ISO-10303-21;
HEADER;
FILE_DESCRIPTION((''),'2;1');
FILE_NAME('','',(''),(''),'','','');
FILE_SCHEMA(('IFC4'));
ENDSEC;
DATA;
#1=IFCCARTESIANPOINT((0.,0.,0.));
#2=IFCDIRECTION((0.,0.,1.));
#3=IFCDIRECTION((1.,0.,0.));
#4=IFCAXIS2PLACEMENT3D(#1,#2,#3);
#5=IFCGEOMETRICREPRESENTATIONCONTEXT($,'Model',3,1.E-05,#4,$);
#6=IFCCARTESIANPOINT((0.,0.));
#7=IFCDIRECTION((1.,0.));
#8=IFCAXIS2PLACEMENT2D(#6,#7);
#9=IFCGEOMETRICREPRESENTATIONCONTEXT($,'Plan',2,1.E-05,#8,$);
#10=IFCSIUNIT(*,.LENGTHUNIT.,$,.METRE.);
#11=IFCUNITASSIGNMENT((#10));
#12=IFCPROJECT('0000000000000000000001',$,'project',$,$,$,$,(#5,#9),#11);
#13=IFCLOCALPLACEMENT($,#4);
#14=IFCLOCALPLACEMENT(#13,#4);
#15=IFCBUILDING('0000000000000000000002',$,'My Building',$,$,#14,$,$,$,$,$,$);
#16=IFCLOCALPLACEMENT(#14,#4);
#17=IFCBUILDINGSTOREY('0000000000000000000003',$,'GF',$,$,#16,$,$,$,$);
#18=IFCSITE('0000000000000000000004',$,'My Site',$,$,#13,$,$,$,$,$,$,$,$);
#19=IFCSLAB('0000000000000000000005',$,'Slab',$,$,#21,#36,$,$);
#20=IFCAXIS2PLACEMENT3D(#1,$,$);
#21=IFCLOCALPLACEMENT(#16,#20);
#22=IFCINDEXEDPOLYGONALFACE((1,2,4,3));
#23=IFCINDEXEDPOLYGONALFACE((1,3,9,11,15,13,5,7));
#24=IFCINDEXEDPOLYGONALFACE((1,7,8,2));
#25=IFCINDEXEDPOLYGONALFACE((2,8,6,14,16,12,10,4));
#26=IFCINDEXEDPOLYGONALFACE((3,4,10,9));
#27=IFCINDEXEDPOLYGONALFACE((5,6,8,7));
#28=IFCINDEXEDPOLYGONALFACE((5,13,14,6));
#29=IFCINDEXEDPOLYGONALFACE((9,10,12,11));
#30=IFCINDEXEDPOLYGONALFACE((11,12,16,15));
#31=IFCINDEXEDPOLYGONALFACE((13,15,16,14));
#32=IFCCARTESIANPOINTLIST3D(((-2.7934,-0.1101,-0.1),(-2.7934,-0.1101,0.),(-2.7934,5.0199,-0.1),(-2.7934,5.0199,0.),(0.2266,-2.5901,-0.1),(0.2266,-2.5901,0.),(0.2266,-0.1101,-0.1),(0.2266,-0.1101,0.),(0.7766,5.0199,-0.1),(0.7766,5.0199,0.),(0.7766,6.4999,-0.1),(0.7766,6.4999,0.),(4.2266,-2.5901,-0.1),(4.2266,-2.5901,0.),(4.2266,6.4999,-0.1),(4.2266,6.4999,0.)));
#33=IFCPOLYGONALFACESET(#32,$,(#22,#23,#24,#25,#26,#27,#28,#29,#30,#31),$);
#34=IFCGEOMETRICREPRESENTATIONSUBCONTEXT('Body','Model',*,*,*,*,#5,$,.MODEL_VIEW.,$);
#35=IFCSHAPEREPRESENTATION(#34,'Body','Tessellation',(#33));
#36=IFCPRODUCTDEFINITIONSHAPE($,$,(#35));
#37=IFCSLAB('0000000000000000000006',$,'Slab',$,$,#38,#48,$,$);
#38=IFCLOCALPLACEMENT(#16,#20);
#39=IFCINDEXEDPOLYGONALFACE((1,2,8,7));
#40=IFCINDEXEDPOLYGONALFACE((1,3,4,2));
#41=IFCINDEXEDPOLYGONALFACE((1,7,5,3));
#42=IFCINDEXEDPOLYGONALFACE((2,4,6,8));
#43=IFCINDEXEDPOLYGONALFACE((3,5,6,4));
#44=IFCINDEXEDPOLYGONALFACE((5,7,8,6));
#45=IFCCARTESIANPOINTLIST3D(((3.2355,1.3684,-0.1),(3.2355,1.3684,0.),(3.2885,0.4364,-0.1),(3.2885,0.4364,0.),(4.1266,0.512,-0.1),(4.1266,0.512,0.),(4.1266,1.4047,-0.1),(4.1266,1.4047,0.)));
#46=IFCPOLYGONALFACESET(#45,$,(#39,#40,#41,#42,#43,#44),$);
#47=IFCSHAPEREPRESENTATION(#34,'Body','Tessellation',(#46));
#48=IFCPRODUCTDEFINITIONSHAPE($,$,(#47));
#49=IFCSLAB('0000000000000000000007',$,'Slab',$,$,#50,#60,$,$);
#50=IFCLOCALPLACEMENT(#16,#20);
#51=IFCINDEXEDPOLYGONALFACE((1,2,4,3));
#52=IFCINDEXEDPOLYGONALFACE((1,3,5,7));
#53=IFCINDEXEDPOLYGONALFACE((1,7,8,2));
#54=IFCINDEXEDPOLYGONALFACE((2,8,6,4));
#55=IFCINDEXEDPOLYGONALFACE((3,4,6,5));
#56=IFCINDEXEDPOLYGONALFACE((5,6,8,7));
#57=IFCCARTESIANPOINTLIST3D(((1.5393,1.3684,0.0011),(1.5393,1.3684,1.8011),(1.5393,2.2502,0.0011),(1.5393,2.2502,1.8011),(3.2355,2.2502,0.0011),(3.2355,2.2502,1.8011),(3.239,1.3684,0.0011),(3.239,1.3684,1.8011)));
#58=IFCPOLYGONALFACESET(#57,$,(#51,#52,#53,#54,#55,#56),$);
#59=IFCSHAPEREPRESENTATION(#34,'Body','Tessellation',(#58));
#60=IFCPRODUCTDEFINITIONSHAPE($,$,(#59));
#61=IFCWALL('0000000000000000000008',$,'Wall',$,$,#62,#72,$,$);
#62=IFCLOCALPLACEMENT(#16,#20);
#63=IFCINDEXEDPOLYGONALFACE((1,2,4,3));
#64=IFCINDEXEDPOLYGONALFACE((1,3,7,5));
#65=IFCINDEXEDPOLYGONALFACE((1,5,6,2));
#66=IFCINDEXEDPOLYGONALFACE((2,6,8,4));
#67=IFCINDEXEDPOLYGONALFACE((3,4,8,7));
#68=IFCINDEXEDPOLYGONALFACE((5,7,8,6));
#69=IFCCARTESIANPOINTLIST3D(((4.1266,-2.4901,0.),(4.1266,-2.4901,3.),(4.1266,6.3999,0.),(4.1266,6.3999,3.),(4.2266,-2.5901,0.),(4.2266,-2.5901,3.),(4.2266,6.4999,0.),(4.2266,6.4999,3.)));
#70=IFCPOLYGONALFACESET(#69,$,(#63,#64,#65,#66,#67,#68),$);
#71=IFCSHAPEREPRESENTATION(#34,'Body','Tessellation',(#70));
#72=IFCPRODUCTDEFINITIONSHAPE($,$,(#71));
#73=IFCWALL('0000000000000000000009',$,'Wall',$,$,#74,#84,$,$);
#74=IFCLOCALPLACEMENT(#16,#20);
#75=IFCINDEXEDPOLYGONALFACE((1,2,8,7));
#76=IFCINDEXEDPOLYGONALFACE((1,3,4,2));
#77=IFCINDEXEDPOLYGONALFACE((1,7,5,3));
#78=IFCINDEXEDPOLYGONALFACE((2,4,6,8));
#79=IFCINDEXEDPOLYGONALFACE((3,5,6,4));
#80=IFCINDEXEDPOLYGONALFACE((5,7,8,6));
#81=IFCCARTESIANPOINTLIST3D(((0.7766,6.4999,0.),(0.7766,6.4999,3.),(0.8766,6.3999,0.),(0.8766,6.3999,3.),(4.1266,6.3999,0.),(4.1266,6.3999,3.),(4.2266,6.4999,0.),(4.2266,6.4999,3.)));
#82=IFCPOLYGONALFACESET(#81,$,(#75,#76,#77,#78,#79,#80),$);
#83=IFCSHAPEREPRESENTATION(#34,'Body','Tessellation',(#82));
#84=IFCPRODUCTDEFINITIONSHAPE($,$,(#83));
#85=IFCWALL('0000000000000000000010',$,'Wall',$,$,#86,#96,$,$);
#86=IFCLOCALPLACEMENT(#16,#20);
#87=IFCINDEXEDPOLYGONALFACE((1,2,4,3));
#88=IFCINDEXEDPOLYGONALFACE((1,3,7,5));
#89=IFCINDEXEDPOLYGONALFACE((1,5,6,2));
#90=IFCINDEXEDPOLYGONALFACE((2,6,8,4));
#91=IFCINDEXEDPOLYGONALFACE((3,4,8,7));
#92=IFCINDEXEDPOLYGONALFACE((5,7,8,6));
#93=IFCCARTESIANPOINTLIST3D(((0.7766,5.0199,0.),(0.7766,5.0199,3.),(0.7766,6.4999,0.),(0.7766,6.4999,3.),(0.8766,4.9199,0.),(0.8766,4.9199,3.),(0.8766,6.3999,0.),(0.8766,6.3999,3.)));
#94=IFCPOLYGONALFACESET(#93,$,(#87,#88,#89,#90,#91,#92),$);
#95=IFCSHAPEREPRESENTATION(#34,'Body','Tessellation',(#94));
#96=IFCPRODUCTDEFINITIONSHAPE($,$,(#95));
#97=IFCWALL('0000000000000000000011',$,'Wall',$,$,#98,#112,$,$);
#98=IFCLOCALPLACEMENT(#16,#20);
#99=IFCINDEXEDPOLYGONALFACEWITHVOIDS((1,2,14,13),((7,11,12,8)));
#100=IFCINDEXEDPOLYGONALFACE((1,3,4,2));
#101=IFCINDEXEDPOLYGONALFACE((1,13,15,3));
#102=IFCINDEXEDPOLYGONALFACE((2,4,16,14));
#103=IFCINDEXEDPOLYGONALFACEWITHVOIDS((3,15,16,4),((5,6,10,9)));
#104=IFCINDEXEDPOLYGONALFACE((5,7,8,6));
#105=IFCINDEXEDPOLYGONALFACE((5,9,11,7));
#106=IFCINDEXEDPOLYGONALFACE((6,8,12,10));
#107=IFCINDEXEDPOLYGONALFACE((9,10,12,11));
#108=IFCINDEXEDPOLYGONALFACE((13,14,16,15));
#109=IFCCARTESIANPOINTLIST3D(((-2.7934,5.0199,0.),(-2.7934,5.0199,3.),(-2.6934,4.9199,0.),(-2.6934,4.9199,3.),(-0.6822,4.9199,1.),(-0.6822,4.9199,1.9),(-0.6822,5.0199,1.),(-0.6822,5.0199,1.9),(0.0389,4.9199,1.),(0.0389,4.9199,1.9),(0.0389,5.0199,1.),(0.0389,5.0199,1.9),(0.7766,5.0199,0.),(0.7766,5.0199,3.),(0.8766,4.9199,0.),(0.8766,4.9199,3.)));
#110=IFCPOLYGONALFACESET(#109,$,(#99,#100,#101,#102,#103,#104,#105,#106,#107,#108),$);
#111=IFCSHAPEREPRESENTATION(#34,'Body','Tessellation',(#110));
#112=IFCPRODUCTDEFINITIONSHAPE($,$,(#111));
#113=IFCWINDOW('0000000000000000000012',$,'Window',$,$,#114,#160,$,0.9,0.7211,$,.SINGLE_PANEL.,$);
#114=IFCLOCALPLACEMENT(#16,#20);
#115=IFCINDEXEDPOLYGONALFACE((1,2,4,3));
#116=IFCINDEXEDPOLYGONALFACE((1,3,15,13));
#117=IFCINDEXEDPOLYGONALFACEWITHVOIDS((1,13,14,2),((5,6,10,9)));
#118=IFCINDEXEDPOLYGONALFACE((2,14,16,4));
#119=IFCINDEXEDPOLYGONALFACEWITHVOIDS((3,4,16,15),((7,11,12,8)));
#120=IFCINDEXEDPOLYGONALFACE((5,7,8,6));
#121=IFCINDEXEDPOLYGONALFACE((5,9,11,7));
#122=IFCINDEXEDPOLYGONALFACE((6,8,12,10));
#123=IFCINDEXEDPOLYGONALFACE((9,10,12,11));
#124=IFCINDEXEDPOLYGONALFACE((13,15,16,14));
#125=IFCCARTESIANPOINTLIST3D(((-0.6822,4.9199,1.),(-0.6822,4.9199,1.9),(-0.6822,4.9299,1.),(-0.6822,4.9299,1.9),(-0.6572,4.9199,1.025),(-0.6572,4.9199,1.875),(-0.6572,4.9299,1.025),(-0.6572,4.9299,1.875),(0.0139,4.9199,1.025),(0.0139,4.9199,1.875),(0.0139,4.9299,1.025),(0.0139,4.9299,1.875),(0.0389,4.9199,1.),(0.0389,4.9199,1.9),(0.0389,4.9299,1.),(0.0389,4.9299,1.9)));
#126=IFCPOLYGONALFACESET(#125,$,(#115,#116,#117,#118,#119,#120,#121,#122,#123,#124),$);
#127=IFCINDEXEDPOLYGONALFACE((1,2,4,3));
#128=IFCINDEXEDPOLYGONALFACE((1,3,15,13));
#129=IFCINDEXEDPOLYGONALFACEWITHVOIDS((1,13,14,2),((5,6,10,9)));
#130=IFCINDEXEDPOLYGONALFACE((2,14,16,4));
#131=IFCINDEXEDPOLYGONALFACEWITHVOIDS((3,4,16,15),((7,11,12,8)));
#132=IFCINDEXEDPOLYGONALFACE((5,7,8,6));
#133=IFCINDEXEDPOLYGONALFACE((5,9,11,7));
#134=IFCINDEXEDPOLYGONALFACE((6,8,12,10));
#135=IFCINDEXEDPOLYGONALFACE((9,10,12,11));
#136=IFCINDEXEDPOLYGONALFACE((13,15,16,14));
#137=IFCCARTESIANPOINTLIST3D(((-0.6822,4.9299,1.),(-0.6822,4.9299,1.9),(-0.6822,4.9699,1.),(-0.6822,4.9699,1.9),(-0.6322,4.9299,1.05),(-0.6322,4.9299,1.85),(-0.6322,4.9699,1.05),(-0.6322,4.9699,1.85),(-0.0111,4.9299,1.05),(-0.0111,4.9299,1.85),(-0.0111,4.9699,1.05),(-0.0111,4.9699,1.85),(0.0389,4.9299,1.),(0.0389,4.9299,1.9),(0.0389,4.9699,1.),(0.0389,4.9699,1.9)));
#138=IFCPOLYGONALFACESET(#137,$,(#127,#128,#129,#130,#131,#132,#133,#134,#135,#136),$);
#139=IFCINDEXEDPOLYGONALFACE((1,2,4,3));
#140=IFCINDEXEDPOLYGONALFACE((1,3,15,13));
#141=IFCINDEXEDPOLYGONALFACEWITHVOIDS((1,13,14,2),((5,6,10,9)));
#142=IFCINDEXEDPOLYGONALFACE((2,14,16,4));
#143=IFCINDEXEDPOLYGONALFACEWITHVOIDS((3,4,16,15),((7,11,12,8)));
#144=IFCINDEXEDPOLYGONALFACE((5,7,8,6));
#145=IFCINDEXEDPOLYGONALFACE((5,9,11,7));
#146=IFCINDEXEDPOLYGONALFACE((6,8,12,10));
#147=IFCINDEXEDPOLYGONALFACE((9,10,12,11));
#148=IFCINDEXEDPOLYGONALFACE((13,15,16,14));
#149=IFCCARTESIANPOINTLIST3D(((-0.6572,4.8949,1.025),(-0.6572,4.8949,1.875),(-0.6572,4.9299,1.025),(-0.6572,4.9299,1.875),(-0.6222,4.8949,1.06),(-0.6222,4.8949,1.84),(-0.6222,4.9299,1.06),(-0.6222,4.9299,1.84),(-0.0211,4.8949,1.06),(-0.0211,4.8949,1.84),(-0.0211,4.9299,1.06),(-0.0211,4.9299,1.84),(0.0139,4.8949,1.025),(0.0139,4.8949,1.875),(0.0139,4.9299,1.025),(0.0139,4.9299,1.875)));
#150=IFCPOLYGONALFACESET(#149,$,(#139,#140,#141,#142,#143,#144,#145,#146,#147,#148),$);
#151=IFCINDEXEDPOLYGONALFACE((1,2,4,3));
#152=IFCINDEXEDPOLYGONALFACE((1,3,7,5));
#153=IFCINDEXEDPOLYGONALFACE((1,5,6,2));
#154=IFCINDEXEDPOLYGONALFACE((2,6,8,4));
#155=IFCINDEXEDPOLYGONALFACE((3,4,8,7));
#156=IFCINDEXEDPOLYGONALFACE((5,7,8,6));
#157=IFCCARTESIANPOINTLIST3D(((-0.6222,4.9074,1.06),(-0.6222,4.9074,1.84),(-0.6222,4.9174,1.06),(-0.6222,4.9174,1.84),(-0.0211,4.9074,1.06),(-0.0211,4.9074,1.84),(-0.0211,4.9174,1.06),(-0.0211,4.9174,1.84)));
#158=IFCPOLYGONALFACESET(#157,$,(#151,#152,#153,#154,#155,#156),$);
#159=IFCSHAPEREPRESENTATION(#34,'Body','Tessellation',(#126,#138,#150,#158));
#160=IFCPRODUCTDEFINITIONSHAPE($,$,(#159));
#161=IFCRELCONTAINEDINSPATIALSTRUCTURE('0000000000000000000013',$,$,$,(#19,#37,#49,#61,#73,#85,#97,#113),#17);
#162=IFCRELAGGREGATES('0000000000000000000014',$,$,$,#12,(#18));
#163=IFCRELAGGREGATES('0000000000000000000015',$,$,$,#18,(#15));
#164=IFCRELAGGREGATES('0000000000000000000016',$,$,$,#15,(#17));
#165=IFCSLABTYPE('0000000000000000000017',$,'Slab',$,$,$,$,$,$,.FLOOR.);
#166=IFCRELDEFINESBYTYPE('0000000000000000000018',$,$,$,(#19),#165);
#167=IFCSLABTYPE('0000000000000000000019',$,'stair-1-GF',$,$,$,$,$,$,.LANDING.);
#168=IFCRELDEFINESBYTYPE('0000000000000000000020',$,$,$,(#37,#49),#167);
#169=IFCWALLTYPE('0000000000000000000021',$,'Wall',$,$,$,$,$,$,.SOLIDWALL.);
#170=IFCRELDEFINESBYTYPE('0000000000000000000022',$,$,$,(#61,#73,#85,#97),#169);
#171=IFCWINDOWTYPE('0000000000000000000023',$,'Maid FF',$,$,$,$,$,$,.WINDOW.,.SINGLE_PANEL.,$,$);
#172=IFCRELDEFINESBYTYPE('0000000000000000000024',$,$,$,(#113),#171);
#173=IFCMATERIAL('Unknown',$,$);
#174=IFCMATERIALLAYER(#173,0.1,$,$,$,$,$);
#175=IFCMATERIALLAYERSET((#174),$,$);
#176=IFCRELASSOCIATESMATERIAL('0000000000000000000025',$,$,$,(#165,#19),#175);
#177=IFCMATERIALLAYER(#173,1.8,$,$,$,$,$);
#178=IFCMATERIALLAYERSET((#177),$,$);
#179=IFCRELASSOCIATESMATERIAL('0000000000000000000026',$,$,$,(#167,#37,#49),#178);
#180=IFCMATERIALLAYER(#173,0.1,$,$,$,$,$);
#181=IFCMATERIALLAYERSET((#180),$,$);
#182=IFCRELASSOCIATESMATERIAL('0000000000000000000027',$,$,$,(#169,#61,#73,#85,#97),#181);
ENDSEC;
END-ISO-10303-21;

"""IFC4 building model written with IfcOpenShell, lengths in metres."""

from ifc_helpers import new_model, entity, si_unit, frame, origin_with_axes, origin_2d_with_axis, place, context, subcontext, project, spatial, line, indexed_curve, outline, extrude, shape, source, transform, mapped, material, layer, layer_set, layer_usage, type_object, type_shapes, element, fill, save


model = new_model("IFC4")

# Units and contexts
model_context = context("Model", 3, precision=1e-05, world=origin_with_axes())
plan_context = context("Plan", 2, precision=1e-05, world=origin_2d_with_axis())
body_context_1 = subcontext(model_context, "Body", "Model", "MODEL_VIEW")
body_context_2 = subcontext(plan_context, "Body", "Plan", "PLAN_VIEW")
ifc_project = project(units=[si_unit("LENGTHUNIT", "METRE")], contexts=[model_context, plan_context])

# Site, building, storey
site_placement = place(None, origin_with_axes())
site = spatial("IfcSite", under=ifc_project, at=site_placement, Name="My Site")
building_placement = place(site_placement, origin_with_axes())
building = spatial("IfcBuilding", under=site, at=building_placement, Name="My Building")
storey_placement = place(building_placement, origin_with_axes())
storey = spatial("IfcBuildingStorey", under=building, at=storey_placement, Name="GF")

# Slabs
ifc_material_1 = material(Name="Unknown")
ifc_layer_1 = layer(ifc_material_1, 0.1)
ifc_layer_set_1 = layer_set([ifc_layer_1])
ifc_layer_usage_1 = layer_usage(ifc_layer_set_1, "AXIS3", "POSITIVE", -0.1)
slab_type_1 = type_object("IfcSlabType", Name="Slab", PredefinedType="FLOOR", material=ifc_layer_set_1)
slab_1_placement = place(storey_placement, frame((4.2266, -2.5901, 0.0), z_axis=(0.0, 0.0, 1.0), x_axis=(1.0, 0.0, 0.0)))
element("IfcSlab", 1, at=slab_1_placement, inside=storey, type_object=slab_type_1, material=ifc_layer_usage_1, Name="Slab", context=body_context_1, shape_type="SweptSolid", body=[
    extrude(outline(indexed_curve([(0.0, 0.0), (0.0, 9.09), (-3.45, 9.09), (-3.45, 7.61), (-7.02, 7.61), (-7.02, 2.48), (-4.0, 2.48), (-4.0, 0.0), (0.0, 0.0)])), frame((0.0, 0.0, -0.1), z_axis=(0.0, 0.0, 1.0), x_axis=(1.0, 0.0, 0.0)), (0.0, 0.0, 1.0), 0.1),
])
ifc_layer_2 = layer(ifc_material_1, 1.8)
ifc_layer_set_2 = layer_set([ifc_layer_2])
ifc_layer_usage_2 = layer_usage(ifc_layer_set_2, "AXIS3", "POSITIVE", -0.1)
slab_type_2 = type_object("IfcSlabType", Name="stair-1-GF", PredefinedType="LANDING", material=ifc_layer_set_2)
slab_2_placement = place(storey_placement, frame((4.1266, 0.512, 0.0), z_axis=(0.0, 0.0, 1.0), x_axis=(1.0, 0.0, 0.0)))
element("IfcSlab", 2, at=slab_2_placement, inside=storey, type_object=slab_type_2, material=ifc_layer_usage_2, Name="Slab", context=body_context_1, shape_type="SweptSolid", body=[
    extrude(outline(indexed_curve([(0.0, 0.0), (0.0, 0.8927), (-0.8911, 0.8564), (-0.8381, -0.0756), (0.0, 0.0)])), frame((0.0, 0.0, -0.1), z_axis=(0.0, 0.0, 1.0), x_axis=(1.0, 0.0, 0.0)), (0.0, 0.0, 1.0), 0.1),
])
ifc_layer_usage_3 = layer_usage(ifc_layer_set_2, "AXIS3", "POSITIVE", -1.8)
slab_3_placement = place(storey_placement, frame((3.239, 1.3684, 1.8011), z_axis=(0.0, 0.0, 1.0), x_axis=(1.0, 0.0, 0.0)))
element("IfcSlab", 3, at=slab_3_placement, inside=storey, type_object=slab_type_2, material=ifc_layer_usage_3, Name="Slab", context=body_context_1, shape_type="SweptSolid", body=[
    extrude(outline(indexed_curve([(0.0, 0.0), (-1.6998, 0.0), (-1.6998, 0.8819), (-0.0035, 0.8819), (0.0, 0.0)])), frame((0.0, 0.0, -1.8), z_axis=(0.0, 0.0, 1.0), x_axis=(1.0, 0.0, 0.0)), (0.0, 0.0, 1.0), 1.8),
])

# Shared definitions
ifc_layer_3 = layer(ifc_material_1, 0.1)
ifc_layer_set_3 = layer_set([ifc_layer_3])
wall_type = type_object("IfcWallType", Name="Wall", PredefinedType="SOLIDWALL", material=ifc_layer_set_3)

# Walls
ifc_layer_usage_4 = layer_usage(ifc_layer_set_3, "AXIS2", "POSITIVE", 0.0)
wall_1_placement = place(storey_placement, frame((4.2266, -2.5901, 0.0), z_axis=(0.0, 0.0, 1.0), x_axis=(0.0, 1.0, 0.0)))
element("IfcWall", 4, at=wall_1_placement, inside=storey, type_object=wall_type, material=ifc_layer_usage_4, Name="Wall", context=body_context_1, shape_type="SweptSolid", body=[
    extrude(outline(indexed_curve([(0.0, 0.0), (0.1, 0.1), (8.99, 0.1), (9.09, 0.0)], segments=[line(1, 2, 3, 4, 1)])), origin_with_axes(), (0.0, 0.0, 1.0), 3.0),
])
ifc_layer_usage_5 = layer_usage(ifc_layer_set_3, "AXIS2", "POSITIVE", 0.0)
wall_2_placement = place(storey_placement, frame((4.2266, 6.4999, 0.0), z_axis=(0.0, 0.0, 1.0), x_axis=(-1.0, 0.0, 0.0)))
element("IfcWall", 5, at=wall_2_placement, inside=storey, type_object=wall_type, material=ifc_layer_usage_5, Name="Wall", context=body_context_1, shape_type="SweptSolid", body=[
    extrude(outline(indexed_curve([(0.0, 0.0), (0.1, 0.1), (3.35, 0.1), (3.45, 0.0)], segments=[line(1, 2, 3, 4, 1)])), origin_with_axes(), (0.0, 0.0, 1.0), 3.0),
])
ifc_layer_usage_6 = layer_usage(ifc_layer_set_3, "AXIS2", "POSITIVE", 0.0)
wall_3_placement = place(storey_placement, frame((0.7766, 6.4999, 0.0), z_axis=(0.0, 0.0, 1.0), x_axis=(0.0, -1.0, 0.0)))
element("IfcWall", 6, at=wall_3_placement, inside=storey, type_object=wall_type, material=ifc_layer_usage_6, Name="Wall", context=body_context_1, shape_type="SweptSolid", body=[
    extrude(outline(indexed_curve([(0.0, 0.0), (0.1, 0.1), (1.58, 0.1), (1.48, 0.0)], segments=[line(1, 2, 3, 4, 1)])), origin_with_axes(), (0.0, 0.0, 1.0), 3.0),
])

# Wall, opening, window
ifc_layer_usage_7 = layer_usage(ifc_layer_set_3, "AXIS2", "POSITIVE", 0.0)
wall_4_placement = place(storey_placement, frame((0.7766, 5.0199, 0.0), z_axis=(0.0, 0.0, 1.0), x_axis=(-1.0, 0.0, 0.0)))
wall_4 = element("IfcWall", 7, at=wall_4_placement, inside=storey, type_object=wall_type, material=ifc_layer_usage_7, Name="Wall", context=body_context_1, shape_type="SweptSolid", body=[
    extrude(outline(indexed_curve([(0.0, 0.0), (-0.1, 0.1), (3.47, 0.1), (3.57, 0.0)], segments=[line(1, 2, 3, 4, 1)])), origin_with_axes(), (0.0, 0.0, 1.0), 3.0),
])
shared_shape_1 = source(origin_with_axes(), body_context_1, "Body", "SweptSolid", [
    extrude(outline(indexed_curve([(0.0, 0.0), (0.7211, 0.0), (0.7211, 0.9), (0.0, 0.9)], segments=[line(1, 2, 3, 4, 1)])), frame((0.0, -0.6, 0.0), z_axis=(0.0, -1.0, 0.0), x_axis=(1.0, 0.0, 0.0)), (0.0, 0.0, -1.0), 1.2),
])
opening_1_placement = place(wall_4_placement, frame((0.7377, 0.0, 1.0), z_axis=(0.0, 0.0, 1.0), x_axis=(1.0, 0.0, 0.0)))
opening_1 = element("IfcOpeningElement", 8, at=opening_1_placement, cuts=wall_4, PredefinedType="OPENING", context=body_context_1, shape_type="MappedRepresentation", body=[
    mapped(shared_shape_1, transform((0.0, 0.0, 0.0), x_axis=(1.0, 0.0, 0.0), y_axis=(0.0, 1.0, 0.0), z_axis=(0.0, 0.0, 1.0), scale=1.0)),
])
window_type_1 = type_object("IfcWindowType", Name="Maid FF", PartitioningType="SINGLE_PANEL", PredefinedType="WINDOW")
shared_shape_2 = source(origin_with_axes(), body_context_1, "Body", "SweptSolid", [
    extrude(outline(indexed_curve([(0.0, 0.0), (0.7211, 0.0), (0.7211, 0.9), (0.0, 0.9)], segments=[line(1, 2, 3, 4, 1)]), holes=[indexed_curve([(0.025, 0.025), (0.6961, 0.025), (0.6961, 0.875), (0.025, 0.875)], segments=[line(1, 2, 3, 4, 1)])]), frame((0.0, 0.09, 0.0), z_axis=(0.0, -1.0, 0.0), x_axis=(1.0, 0.0, 0.0)), (0.0, 0.0, -1.0), 0.01),
    extrude(outline(indexed_curve([(0.0, 0.0), (0.7211, 0.0), (0.7211, 0.9), (0.0, 0.9)], segments=[line(1, 2, 3, 4, 1)]), holes=[indexed_curve([(0.05, 0.05), (0.6711, 0.05), (0.6711, 0.85), (0.05, 0.85)], segments=[line(1, 2, 3, 4, 1)])]), frame((0.0, 0.05, 0.0), z_axis=(0.0, -1.0, 0.0), x_axis=(1.0, 0.0, 0.0)), (0.0, 0.0, -1.0), 0.04),
    extrude(outline(indexed_curve([(0.0, 0.0), (0.6711, 0.0), (0.6711, 0.85), (0.0, 0.85)], segments=[line(1, 2, 3, 4, 1)]), holes=[indexed_curve([(0.035, 0.035), (0.6361, 0.035), (0.6361, 0.815), (0.035, 0.815)], segments=[line(1, 2, 3, 4, 1)])]), frame((0.025, 0.09, 0.025), z_axis=(0.0, -1.0, 0.0), x_axis=(1.0, 0.0, 0.0)), (0.0, 0.0, -1.0), 0.035),
    extrude(outline(indexed_curve([(0.035, 0.035), (0.6361, 0.035), (0.6361, 0.815), (0.035, 0.815)], segments=[line(1, 2, 3, 4, 1)])), frame((0.025, 0.1025, 0.025), z_axis=(0.0, -1.0, 0.0), x_axis=(1.0, 0.0, 0.0)), (0.0, 0.0, -1.0), 0.01),
])
shared_shape_3 = source(origin_with_axes(), body_context_2, "Body", "Curve2D", [
    entity("IfcIndexedPolyCurve", entity("IfcCartesianPointList2D", [[0.05, 0.05], [0.6711, 0.05]])),
    entity("IfcIndexedPolyCurve", entity("IfcCartesianPointList2D", [[0.0, 0.1], [0.025, 0.1], [0.025, 0.09], [0.05, 0.09], [0.05, 0.05], [0.0, 0.05]]), [entity("IfcLineIndex", [1, 2, 3, 4, 5, 6, 1])]),
    entity("IfcIndexedPolyCurve", entity("IfcCartesianPointList2D", [[0.7211, 0.1], [0.6961, 0.1], [0.6961, 0.09], [0.6711, 0.09], [0.6711, 0.05], [0.7211, 0.05]]), [entity("IfcLineIndex", [1, 2, 3, 4, 5, 6, 1])]),
    entity("IfcIndexedPolyCurve", entity("IfcCartesianPointList2D", [[0.025, 0.09], [0.06, 0.09], [0.06, 0.125], [0.025, 0.125]]), [entity("IfcLineIndex", [1, 2, 3, 4, 1])]),
    entity("IfcIndexedPolyCurve", entity("IfcCartesianPointList2D", [[0.6961, 0.09], [0.6611, 0.09], [0.6611, 0.125], [0.6961, 0.125]]), [entity("IfcLineIndex", [1, 2, 3, 4, 1])]),
    entity("IfcIndexedPolyCurve", entity("IfcCartesianPointList2D", [[0.06, 0.09], [0.6611, 0.09]])),
    entity("IfcIndexedPolyCurve", entity("IfcCartesianPointList2D", [[0.06, 0.125], [0.6611, 0.125]])),
    entity("IfcIndexedPolyCurve", entity("IfcCartesianPointList2D", [[0.06, 0.1075], [0.6611, 0.1075]])),
])
type_shapes(window_type_1, [shared_shape_2, shared_shape_3])
window_1_placement = place(opening_1_placement, frame((0.0, 0.0, 0.0), z_axis=(0.0, 0.0, 1.0), x_axis=(1.0, 0.0, 0.0)))
window_1 = element("IfcWindow", 9, at=window_1_placement, inside=storey, type_object=window_type_1, Name="Window", OverallHeight=0.9, OverallWidth=0.7211, PartitioningType="SINGLE_PANEL", shapes=[
    shape(body_context_1, "Body", "MappedRepresentation", [mapped(shared_shape_2, transform((0.0, 0.0, 0.0), x_axis=(1.0, 0.0, 0.0), y_axis=(0.0, 1.0, 0.0), z_axis=(0.0, 0.0, 1.0), scale=1.0))]),
    shape(body_context_2, "Body", "MappedRepresentation", [mapped(shared_shape_3, transform((0.0, 0.0, 0.0), x_axis=(1.0, 0.0, 0.0), y_axis=(0.0, 1.0, 0.0), z_axis=(0.0, 0.0, 1.0), scale=1.0))]),
])
fill(opening_1, window_1)

save(model, "model.ifc")
